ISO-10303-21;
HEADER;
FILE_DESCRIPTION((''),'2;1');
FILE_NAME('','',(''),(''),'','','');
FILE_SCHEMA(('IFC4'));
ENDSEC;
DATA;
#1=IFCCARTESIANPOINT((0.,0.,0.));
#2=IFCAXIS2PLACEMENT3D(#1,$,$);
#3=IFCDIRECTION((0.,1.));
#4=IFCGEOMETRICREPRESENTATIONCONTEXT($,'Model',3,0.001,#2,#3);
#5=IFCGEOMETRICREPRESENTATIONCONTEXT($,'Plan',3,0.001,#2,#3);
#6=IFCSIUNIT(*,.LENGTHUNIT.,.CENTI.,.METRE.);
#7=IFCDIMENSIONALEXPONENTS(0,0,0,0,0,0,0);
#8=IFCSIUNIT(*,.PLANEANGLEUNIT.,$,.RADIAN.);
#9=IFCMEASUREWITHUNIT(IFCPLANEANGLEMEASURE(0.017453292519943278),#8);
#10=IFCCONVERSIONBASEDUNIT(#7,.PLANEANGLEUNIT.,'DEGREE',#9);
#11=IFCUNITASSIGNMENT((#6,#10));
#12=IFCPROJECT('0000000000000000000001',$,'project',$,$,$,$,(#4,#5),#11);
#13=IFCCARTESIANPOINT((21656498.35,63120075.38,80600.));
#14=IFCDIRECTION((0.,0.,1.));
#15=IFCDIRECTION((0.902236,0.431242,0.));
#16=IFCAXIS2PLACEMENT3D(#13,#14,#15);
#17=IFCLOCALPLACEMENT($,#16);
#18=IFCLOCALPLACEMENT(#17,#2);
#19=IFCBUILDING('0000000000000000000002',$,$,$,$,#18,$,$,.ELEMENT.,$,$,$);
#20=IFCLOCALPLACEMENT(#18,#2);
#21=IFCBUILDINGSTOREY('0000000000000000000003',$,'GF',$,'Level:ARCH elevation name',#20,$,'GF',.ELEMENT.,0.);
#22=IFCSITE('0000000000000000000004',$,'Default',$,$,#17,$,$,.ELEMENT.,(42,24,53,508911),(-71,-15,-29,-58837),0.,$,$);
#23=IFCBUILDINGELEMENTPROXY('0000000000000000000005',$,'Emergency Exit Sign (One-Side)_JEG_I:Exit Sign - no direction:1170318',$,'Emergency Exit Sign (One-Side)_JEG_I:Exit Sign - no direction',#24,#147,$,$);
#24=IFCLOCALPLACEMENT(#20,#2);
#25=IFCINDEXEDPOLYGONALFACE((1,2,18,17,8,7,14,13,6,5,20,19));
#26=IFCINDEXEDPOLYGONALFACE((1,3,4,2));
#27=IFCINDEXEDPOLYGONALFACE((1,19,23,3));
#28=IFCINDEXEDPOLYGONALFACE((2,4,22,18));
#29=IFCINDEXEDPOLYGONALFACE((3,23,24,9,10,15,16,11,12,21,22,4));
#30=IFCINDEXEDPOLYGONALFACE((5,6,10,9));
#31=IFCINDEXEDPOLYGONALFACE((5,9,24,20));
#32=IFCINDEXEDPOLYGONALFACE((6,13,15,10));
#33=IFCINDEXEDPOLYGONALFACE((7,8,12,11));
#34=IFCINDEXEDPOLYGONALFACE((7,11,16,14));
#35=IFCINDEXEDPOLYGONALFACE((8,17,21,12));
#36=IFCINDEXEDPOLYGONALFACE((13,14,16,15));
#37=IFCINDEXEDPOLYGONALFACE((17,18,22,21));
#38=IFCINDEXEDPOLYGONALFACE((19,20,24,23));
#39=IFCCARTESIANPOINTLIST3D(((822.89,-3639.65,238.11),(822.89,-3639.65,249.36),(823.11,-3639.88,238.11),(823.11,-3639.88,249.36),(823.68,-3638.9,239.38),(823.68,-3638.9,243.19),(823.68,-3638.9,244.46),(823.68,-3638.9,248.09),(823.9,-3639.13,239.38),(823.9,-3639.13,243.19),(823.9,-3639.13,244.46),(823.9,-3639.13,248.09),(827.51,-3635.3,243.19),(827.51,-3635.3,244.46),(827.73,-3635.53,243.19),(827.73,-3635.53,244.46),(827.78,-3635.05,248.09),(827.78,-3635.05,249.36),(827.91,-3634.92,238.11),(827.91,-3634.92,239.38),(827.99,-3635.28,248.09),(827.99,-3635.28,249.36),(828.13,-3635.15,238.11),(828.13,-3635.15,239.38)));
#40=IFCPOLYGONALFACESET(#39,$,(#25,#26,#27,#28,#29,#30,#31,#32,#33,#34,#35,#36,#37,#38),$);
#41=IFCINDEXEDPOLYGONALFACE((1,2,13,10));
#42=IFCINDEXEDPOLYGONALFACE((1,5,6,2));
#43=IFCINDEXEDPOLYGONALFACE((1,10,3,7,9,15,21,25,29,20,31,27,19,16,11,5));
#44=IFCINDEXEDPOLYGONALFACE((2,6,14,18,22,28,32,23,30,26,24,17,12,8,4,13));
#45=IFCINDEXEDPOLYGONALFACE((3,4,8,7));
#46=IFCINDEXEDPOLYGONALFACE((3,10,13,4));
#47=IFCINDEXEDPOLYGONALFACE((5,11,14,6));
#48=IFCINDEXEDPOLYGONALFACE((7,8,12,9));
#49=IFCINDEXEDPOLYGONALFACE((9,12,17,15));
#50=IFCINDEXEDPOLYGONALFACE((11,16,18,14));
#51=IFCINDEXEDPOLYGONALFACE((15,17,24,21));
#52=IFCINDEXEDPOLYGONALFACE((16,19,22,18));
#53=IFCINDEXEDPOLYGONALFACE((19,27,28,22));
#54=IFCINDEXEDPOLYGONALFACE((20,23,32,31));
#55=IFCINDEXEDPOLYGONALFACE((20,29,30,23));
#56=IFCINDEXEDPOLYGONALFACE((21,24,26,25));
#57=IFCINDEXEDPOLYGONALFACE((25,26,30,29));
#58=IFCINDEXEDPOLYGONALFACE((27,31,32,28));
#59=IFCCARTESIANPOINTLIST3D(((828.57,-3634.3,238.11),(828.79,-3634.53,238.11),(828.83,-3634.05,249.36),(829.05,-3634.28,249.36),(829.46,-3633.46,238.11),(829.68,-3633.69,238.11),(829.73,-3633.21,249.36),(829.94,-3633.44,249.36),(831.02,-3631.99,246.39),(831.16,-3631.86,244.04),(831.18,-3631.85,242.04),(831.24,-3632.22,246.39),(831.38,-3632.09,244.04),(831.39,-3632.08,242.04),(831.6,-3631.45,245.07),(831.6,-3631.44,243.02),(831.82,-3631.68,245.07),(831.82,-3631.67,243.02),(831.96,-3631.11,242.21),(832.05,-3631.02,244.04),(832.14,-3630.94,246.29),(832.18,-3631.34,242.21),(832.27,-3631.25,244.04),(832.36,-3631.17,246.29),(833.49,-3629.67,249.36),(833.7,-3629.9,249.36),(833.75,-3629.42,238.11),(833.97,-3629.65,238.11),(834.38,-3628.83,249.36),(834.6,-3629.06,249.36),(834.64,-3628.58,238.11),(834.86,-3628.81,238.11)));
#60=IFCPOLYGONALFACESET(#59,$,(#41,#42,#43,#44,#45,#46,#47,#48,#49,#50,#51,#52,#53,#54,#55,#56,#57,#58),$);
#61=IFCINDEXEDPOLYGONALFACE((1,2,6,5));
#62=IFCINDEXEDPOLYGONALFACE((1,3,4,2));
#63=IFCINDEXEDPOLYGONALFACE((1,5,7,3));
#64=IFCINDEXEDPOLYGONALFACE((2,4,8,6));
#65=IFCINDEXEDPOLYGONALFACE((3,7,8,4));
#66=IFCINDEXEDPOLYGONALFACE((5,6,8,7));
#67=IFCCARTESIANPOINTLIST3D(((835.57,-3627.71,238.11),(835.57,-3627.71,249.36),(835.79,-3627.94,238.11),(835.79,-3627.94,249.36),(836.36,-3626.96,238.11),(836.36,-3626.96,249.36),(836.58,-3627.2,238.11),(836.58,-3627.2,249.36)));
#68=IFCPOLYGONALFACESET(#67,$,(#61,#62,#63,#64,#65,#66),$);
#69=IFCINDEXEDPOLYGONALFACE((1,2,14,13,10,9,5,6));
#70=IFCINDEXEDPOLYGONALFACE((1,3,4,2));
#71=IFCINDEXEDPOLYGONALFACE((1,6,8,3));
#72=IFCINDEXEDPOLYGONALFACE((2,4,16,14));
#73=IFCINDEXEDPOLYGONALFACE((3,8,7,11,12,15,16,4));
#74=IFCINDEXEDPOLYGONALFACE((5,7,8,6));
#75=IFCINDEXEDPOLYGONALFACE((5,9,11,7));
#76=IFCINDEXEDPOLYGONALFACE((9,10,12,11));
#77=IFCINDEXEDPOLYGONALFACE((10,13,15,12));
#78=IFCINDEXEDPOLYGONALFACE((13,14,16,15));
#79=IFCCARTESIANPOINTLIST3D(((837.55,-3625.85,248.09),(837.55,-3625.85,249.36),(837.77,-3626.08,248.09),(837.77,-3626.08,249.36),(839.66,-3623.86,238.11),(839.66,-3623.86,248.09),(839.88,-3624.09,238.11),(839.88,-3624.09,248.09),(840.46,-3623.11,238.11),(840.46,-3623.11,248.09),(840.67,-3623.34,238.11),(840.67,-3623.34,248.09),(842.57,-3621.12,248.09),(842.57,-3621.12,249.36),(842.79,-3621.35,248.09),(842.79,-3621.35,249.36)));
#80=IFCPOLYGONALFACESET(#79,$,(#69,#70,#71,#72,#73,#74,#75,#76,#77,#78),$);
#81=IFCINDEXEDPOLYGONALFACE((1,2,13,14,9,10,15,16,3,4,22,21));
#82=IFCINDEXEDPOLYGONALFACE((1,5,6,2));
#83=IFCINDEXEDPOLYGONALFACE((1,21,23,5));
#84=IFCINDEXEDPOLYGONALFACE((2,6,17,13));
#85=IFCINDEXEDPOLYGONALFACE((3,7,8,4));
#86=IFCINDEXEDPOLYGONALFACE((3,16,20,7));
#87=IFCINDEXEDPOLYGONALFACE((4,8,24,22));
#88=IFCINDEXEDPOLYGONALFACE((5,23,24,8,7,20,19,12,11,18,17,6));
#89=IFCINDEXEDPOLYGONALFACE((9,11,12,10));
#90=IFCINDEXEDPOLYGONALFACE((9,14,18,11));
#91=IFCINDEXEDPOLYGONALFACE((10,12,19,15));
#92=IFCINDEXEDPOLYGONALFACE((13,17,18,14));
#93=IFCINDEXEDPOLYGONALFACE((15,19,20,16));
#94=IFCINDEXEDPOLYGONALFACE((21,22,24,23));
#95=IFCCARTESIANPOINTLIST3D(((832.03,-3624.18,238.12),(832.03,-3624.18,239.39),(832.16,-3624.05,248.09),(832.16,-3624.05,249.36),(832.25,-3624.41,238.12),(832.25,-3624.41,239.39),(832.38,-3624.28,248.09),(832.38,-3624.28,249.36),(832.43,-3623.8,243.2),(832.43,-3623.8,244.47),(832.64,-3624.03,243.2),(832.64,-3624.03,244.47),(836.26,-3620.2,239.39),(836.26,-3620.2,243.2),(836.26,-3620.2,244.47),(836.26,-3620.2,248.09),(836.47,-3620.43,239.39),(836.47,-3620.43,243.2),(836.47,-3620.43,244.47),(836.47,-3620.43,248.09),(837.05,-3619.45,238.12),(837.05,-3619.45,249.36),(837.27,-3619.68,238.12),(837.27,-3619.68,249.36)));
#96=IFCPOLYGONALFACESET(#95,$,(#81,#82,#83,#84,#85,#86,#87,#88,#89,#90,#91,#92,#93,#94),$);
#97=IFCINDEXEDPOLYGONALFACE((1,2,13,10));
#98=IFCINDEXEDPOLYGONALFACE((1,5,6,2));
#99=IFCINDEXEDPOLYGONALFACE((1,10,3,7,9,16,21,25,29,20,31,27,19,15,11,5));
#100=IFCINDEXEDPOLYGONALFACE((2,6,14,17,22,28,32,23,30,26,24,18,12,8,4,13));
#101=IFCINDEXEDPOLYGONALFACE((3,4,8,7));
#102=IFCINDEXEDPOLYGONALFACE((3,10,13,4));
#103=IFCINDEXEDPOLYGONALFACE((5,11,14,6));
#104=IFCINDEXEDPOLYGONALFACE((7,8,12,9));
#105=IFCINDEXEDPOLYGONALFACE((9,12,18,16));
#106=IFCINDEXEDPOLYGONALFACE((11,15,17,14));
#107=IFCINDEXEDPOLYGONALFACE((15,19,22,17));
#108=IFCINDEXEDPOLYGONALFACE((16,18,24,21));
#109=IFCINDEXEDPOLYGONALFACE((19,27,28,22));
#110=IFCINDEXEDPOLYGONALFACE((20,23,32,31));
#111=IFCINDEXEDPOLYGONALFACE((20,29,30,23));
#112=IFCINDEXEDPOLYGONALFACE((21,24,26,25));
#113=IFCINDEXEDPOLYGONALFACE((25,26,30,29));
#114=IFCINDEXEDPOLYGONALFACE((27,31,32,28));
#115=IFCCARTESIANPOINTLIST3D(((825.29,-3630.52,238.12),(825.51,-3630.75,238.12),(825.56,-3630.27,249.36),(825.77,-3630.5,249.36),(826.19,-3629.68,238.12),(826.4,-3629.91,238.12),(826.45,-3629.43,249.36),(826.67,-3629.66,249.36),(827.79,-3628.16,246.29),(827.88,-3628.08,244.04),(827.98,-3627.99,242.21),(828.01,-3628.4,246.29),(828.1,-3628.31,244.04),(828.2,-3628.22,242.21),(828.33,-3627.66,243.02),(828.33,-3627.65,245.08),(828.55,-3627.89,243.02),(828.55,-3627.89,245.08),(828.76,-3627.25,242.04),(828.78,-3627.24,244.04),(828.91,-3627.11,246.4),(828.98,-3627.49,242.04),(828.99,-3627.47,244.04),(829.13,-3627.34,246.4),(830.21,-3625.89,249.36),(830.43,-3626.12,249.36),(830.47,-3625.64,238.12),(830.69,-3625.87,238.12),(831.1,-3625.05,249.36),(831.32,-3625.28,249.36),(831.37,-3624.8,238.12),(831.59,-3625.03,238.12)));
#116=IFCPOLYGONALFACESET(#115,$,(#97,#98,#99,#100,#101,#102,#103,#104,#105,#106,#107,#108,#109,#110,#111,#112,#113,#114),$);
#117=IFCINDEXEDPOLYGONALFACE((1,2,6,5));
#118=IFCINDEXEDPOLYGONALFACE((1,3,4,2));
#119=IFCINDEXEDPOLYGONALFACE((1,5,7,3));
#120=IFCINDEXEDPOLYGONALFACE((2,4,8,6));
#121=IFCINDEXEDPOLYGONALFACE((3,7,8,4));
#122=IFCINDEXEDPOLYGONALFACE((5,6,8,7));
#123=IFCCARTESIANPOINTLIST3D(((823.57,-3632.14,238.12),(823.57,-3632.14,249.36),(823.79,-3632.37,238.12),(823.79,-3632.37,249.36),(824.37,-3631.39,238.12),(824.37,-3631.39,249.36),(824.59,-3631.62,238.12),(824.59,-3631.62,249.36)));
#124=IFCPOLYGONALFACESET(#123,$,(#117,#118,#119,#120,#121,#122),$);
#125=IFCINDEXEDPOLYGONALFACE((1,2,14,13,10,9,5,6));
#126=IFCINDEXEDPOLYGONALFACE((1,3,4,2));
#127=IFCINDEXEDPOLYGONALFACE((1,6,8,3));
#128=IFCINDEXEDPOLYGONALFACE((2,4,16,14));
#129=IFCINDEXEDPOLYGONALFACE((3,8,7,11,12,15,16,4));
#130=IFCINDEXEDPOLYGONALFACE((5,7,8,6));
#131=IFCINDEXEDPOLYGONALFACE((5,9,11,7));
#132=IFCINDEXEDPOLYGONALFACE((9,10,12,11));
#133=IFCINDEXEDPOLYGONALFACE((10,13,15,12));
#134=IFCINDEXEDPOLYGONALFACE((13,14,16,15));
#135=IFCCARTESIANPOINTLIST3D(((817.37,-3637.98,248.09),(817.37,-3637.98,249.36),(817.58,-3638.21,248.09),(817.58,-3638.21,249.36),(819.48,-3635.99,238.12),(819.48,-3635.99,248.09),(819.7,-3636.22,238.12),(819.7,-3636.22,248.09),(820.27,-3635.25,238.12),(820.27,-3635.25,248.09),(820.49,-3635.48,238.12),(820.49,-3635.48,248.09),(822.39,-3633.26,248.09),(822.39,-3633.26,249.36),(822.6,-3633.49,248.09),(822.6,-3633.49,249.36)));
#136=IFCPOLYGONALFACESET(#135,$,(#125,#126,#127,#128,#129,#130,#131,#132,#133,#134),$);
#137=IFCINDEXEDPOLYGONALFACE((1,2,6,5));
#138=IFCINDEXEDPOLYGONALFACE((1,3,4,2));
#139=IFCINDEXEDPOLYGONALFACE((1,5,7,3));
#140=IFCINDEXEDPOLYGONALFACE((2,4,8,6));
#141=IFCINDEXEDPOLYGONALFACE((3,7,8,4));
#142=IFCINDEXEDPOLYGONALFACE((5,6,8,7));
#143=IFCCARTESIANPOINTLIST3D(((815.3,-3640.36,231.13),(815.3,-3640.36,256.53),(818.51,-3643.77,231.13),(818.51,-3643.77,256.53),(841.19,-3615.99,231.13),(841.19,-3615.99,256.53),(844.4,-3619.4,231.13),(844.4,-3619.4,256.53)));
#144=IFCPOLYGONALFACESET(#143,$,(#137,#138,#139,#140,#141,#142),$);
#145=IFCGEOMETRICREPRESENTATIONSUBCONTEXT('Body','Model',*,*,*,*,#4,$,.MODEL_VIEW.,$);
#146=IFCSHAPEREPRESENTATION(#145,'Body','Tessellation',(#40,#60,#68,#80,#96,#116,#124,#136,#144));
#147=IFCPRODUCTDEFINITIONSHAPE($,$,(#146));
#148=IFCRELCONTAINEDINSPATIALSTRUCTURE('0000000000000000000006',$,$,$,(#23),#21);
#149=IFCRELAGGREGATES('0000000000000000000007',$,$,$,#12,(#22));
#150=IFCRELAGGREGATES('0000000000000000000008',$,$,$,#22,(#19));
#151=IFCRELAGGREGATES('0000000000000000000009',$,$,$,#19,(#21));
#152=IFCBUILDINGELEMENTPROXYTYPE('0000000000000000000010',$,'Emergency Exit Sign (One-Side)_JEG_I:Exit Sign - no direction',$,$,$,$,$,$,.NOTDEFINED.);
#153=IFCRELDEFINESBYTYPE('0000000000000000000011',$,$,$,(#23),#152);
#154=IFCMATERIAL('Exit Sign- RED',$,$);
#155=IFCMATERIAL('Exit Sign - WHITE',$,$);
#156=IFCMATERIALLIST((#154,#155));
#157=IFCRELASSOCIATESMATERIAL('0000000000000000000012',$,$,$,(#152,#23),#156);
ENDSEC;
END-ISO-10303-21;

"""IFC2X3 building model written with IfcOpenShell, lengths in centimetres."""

from ifc_helpers import new_model, entity, si_unit, converted_unit, direction, frame, frame_2d, origin, origin_2d_with_axis, place, context, subcontext, project, spatial, polyline, rectangle, outline, extrude, source, transform, mapped, material, material_list, type_object, type_shapes, element, save


model = new_model("IFC2X3")

# Units and contexts
model_context = context("Model", 3, precision=0.001, world=origin(), true_north=direction((0.0, 1.0)))
plan_context = context("Plan", 3, precision=0.001, world=origin(), true_north=direction((0.0, 1.0)))
body_context = subcontext(model_context, "Body", "Model", "MODEL_VIEW")
ifc_project = project(units=[si_unit("LENGTHUNIT", "METRE", prefix="CENTI"), converted_unit("PLANEANGLEUNIT", "DEGREE", entity("IfcPlaneAngleMeasure", 0.017453292519943278), si_unit("PLANEANGLEUNIT", "RADIAN"), dimensions=[0, 0, 0, 0, 0, 0, 0])], contexts=[model_context, plan_context])

# Site, building, storey
site_placement = place(None, frame((21656498.35, 63120075.38, 80600.0), z_axis=(0.0, 0.0, 1.0), x_axis=(0.902236, 0.431242, 0.0)))
site = spatial("IfcSite", under=ifc_project, at=site_placement, Name="Default", CompositionType="ELEMENT", RefLatitude=(42, 24, 53, 508911), RefLongitude=(-71, -15, -29, -58837), RefElevation=0.0)
building_placement = place(site_placement, origin())
building = spatial("IfcBuilding", under=site, at=building_placement, CompositionType="ELEMENT")
storey_placement = place(building_placement, origin())
storey = spatial("IfcBuildingStorey", under=building, at=storey_placement, Name="GF", ObjectType="Level:ARCH elevation name", LongName="GF", CompositionType="ELEMENT", Elevation=0.0)

# Shared definitions
ifc_material_1 = material(Name="Exit Sign - WHITE")
ifc_material_2 = material(Name="Exit Sign- RED")

# Building element proxy
ifc_material_list_1 = material_list([ifc_material_2, ifc_material_1])
building_element_proxy_type_1 = type_object("IfcBuildingElementProxyType", Name="Emergency Exit Sign (One-Side)_JEG_I:Exit Sign - no direction", PredefinedType="NOTDEFINED", material=ifc_material_list_1)
shared_shape_1 = source(origin(), body_context, "Body", "SweptSolid", [
    extrude(outline(polyline([(-5.65, -3.69), (5.59, -3.69), (5.59, 3.02), (4.32, 3.02), (4.32, -2.6), (0.7, -2.6), (0.7, 2.66), (-0.57, 2.66), (-0.57, -2.6), (-4.38, -2.6), (-4.38, 3.21), (-5.65, 3.21), (-5.65, -3.69)])), frame((-8.08, -5.22, 12.64), z_axis=(0.0, 1.0, 0.0), x_axis=(0.0, 0.0, 1.0)), (0.0, 0.0, 1.0), 0.32),
    extrude(outline(polyline([(-7.14, 0.57), (-6.5, -0.49), (-1.93, -0.48), (-0.78, -0.48), (-1.23, -1.32), (-3.47, -5.53), (-2.84, -6.59), (0.41, -0.48), (6.62, -0.48), (5.99, 0.57), (2.4, 0.57), (0.98, 0.58), (1.7, 1.94), (3.32, 5.0), (2.69, 6.05), (-0.22, 0.57), (-7.14, 0.57)])), frame((0.2, -5.22, 12.81), z_axis=(0.0, -1.0, 0.0), x_axis=(0.515099, 0.0, 0.857131)), (0.0, 0.0, -1.0), 0.32),
    extrude(rectangle(XDim=0.32, YDim=1.09, at=frame_2d((0.0, 0.0), x_axis=(1.0, 0.0))), frame((6.19, -5.06, 6.99), z_axis=(0.0, 0.0, 1.0), x_axis=(0.0, 1.0, 0.0)), (0.0, 0.0, 1.0), 11.25),
    extrude(outline(polyline([(-7.8, 0.54), (-7.8, -0.54), (2.18, -0.54), (2.18, -3.45), (3.45, -3.45), (3.45, 3.45), (2.18, 3.45), (2.18, 0.54), (-7.8, 0.54)])), frame((11.82, -5.22, 14.79), z_axis=(0.0, -1.0, 0.0), x_axis=(0.0, 0.0, 1.0)), (0.0, 0.0, -1.0), 0.32),
    extrude(outline(polyline([(-3.69, -5.65), (3.21, -5.65), (3.21, -4.38), (-2.6, -4.38), (-2.6, -0.57), (2.66, -0.57), (2.66, 0.7), (-2.6, 0.7), (-2.6, 4.32), (3.02, 4.32), (3.02, 5.59), (-3.69, 5.59), (-3.69, -5.65)])), frame((8.7, -0.22, 12.65), z_axis=(0.0, 1.0, 0.0), x_axis=(-1.0, 0.0, 0.0)), (0.0, 0.0, 1.0), 0.32),
    extrude(outline(polyline([(-4.16, -5.82), (-2.93, -5.82), (-0.58, -1.9), (0.01, -0.92), (0.5, -1.73), (2.96, -5.82), (4.18, -5.82), (0.62, 0.1), (3.82, 5.42), (2.59, 5.42), (0.75, 2.35), (0.01, 1.14), (-0.79, 2.46), (-2.57, 5.42), (-3.8, 5.42), (-0.6, 0.1), (-4.16, -5.82)])), frame((0.43, -0.22, 12.82), z_axis=(0.0, 1.0, 0.0), x_axis=(-1.0, 0.0, 0.0)), (0.0, 0.0, 1.0), 0.32),
    extrude(rectangle(XDim=0.32, YDim=1.09, at=origin_2d_with_axis()), frame((-5.57, -0.06, 6.99), z_axis=(0.0, 0.0, 1.0), x_axis=(0.0, -1.0, 0.0)), (0.0, 0.0, 1.0), 11.25),
    extrude(outline(polyline([(-0.54, -7.8), (0.54, -7.8), (0.54, 2.18), (3.45, 2.18), (3.45, 3.45), (-3.45, 3.45), (-3.45, 2.18), (-0.54, 2.18), (-0.54, -7.8)])), frame((-11.2, -0.22, 14.79), z_axis=(0.0, 1.0, 0.0), x_axis=(-1.0, 0.0, 0.0)), (0.0, 0.0, 1.0), 0.32),
    extrude(rectangle(XDim=4.68, YDim=35.56, at=origin_2d_with_axis()), frame((0.0, -2.56, 0.01), z_axis=(0.0, 0.0, 1.0), x_axis=(0.0, 1.0, 0.0)), (0.0, 0.0, 1.0), 25.4),
])
type_shapes(building_element_proxy_type_1, [shared_shape_1])
for number, where, z_axis, x_axis, name in (
    (1, (828.09, -3628.01, 231.12), (0.0, 0.0, 1.0), (0.728093, 0.685479, 0.0), "Emergency Exit Sign (One-Side)_JEG_I:Exit Sign - no direction:1170318"),
):
    element("IfcBuildingElementProxy", number, at=place(storey_placement, frame(where, z_axis=z_axis, x_axis=x_axis)), inside=storey, type_object=building_element_proxy_type_1, material=ifc_material_list_1, Name=name, ObjectType="Emergency Exit Sign (One-Side)_JEG_I:Exit Sign - no direction", context=body_context, shape_type="MappedRepresentation", body=[
        mapped(shared_shape_1, transform((0.0, 0.0, 0.0), scale=1.0)),
    ])

save(model, "model.ifc")
